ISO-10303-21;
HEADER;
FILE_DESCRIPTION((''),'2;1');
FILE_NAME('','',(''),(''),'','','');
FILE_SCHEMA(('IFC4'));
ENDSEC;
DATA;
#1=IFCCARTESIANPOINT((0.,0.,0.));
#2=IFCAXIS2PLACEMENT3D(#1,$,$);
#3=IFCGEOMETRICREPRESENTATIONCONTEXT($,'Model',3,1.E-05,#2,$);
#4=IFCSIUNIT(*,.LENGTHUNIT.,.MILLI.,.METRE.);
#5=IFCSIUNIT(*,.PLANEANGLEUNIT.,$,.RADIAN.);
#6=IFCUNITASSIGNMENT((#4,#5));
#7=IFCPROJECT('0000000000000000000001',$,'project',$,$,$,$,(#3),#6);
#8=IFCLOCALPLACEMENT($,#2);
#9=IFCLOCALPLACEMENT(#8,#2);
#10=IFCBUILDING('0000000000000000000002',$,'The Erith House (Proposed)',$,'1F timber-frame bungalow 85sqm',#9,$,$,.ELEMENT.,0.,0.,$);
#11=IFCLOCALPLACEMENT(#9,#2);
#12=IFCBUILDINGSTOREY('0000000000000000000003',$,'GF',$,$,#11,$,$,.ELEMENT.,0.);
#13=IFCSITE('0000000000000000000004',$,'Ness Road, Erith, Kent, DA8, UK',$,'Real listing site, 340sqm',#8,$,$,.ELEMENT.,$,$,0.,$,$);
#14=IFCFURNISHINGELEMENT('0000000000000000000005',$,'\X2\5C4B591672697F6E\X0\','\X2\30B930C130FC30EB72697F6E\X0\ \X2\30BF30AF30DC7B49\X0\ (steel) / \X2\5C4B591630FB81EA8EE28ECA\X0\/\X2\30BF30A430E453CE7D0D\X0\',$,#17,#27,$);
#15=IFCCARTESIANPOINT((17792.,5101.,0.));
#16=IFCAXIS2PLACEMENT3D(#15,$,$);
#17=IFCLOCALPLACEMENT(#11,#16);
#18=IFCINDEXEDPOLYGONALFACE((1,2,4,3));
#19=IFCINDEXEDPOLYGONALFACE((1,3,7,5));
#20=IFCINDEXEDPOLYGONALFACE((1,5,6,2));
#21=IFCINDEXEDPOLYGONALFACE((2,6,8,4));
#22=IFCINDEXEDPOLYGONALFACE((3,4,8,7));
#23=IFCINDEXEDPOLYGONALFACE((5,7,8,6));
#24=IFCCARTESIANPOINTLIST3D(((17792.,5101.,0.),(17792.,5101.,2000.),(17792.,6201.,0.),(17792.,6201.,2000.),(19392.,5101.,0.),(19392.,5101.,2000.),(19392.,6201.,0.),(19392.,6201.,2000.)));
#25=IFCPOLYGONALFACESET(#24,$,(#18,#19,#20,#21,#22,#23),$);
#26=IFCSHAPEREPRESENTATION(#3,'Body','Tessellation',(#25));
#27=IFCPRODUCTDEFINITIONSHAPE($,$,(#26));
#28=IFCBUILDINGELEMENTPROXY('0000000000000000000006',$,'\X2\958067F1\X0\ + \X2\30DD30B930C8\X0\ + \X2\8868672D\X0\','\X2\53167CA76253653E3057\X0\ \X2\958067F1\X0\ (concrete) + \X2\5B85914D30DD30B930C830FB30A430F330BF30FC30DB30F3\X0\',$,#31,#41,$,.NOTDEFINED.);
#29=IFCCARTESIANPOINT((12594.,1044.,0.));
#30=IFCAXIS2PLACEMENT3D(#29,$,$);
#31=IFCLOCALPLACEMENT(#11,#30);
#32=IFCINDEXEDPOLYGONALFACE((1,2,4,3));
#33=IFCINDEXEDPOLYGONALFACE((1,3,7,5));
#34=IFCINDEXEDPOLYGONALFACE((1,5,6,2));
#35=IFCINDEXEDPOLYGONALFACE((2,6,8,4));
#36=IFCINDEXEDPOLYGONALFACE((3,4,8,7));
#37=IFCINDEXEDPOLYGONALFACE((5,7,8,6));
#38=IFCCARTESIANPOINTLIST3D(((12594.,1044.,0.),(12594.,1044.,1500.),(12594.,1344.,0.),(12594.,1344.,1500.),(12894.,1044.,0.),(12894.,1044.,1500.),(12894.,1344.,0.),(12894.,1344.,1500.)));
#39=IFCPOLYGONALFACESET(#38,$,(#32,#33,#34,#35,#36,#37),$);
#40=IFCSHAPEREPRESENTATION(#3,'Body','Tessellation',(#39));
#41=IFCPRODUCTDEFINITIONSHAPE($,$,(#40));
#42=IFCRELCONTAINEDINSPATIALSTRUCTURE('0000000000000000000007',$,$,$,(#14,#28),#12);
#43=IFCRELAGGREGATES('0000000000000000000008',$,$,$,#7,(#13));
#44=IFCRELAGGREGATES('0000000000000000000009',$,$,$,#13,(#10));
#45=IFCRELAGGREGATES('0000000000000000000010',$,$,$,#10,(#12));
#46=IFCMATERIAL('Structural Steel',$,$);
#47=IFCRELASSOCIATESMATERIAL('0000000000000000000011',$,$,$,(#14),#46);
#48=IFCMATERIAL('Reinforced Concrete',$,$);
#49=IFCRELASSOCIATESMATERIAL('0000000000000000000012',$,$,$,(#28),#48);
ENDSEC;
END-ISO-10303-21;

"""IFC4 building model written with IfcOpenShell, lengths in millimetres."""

from ifc_helpers import new_model, si_unit, frame, frame_2d, origin, place, context, project, spatial, rectangle, extrude, material, element, save


model = new_model("IFC4")

# Units and contexts
model_context = context("Model", 3, precision=1e-05, world=origin())
ifc_project = project(units=[si_unit("LENGTHUNIT", "METRE", prefix="MILLI"), si_unit("PLANEANGLEUNIT", "RADIAN")], contexts=[model_context])

# Site, building, storey
site_placement = place(None, origin())
site = spatial("IfcSite", under=ifc_project, at=site_placement, Name="Ness Road, Erith, Kent, DA8, UK", ObjectType="Real listing site, 340sqm", CompositionType="ELEMENT", RefElevation=0.0)
building_placement = place(site_placement, origin())
building = spatial("IfcBuilding", under=site, at=building_placement, Name="The Erith House (Proposed)", ObjectType="1F timber-frame bungalow 85sqm", CompositionType="ELEMENT", ElevationOfRefHeight=0.0, ElevationOfTerrain=0.0)
storey_placement = place(building_placement, origin())
storey = spatial("IfcBuildingStorey", under=building, at=storey_placement, Name="GF", CompositionType="ELEMENT", Elevation=0.0)

# Shared definitions
ifc_material_1 = material(Name="Reinforced Concrete")

# Shared definitions
ifc_material_2 = material(Name="Structural Steel")

# Furnishing element
furnishing_1_placement = place(storey_placement, frame((17792.0, 5101.0, 0.0)))
element("IfcFurnishingElement", 1, at=furnishing_1_placement, inside=storey, material=ifc_material_2, Name="屋外物置", Description="スチール物置 タクボ等 (steel) / 屋外・自転車/タイヤ収納", context=model_context, shape_type="SweptSolid", body=[
    extrude(rectangle(XDim=1600.0, YDim=1100.0, at=frame_2d((800.0, 550.0))), frame((17792.0, 5101.0, 0.0)), (0.0, 0.0, 1.0), 2000.0),
])

# Building element proxy
proxy_placement = place(storey_placement, frame((12594.0, 1044.0, 0.0)))
element("IfcBuildingElementProxy", 2, at=proxy_placement, inside=storey, material=ifc_material_1, Name="門柱 + ポスト + 表札", Description="化粧打放し 門柱 (concrete) + 宅配ポスト・インターホン", PredefinedType="NOTDEFINED", context=model_context, shape_type="SweptSolid", body=[
    extrude(rectangle(XDim=300.0, YDim=300.0, at=frame_2d((150.0, 150.0))), frame((12594.0, 1044.0, 0.0)), (0.0, 0.0, 1.0), 1500.0),
])

save(model, "model.ifc")
